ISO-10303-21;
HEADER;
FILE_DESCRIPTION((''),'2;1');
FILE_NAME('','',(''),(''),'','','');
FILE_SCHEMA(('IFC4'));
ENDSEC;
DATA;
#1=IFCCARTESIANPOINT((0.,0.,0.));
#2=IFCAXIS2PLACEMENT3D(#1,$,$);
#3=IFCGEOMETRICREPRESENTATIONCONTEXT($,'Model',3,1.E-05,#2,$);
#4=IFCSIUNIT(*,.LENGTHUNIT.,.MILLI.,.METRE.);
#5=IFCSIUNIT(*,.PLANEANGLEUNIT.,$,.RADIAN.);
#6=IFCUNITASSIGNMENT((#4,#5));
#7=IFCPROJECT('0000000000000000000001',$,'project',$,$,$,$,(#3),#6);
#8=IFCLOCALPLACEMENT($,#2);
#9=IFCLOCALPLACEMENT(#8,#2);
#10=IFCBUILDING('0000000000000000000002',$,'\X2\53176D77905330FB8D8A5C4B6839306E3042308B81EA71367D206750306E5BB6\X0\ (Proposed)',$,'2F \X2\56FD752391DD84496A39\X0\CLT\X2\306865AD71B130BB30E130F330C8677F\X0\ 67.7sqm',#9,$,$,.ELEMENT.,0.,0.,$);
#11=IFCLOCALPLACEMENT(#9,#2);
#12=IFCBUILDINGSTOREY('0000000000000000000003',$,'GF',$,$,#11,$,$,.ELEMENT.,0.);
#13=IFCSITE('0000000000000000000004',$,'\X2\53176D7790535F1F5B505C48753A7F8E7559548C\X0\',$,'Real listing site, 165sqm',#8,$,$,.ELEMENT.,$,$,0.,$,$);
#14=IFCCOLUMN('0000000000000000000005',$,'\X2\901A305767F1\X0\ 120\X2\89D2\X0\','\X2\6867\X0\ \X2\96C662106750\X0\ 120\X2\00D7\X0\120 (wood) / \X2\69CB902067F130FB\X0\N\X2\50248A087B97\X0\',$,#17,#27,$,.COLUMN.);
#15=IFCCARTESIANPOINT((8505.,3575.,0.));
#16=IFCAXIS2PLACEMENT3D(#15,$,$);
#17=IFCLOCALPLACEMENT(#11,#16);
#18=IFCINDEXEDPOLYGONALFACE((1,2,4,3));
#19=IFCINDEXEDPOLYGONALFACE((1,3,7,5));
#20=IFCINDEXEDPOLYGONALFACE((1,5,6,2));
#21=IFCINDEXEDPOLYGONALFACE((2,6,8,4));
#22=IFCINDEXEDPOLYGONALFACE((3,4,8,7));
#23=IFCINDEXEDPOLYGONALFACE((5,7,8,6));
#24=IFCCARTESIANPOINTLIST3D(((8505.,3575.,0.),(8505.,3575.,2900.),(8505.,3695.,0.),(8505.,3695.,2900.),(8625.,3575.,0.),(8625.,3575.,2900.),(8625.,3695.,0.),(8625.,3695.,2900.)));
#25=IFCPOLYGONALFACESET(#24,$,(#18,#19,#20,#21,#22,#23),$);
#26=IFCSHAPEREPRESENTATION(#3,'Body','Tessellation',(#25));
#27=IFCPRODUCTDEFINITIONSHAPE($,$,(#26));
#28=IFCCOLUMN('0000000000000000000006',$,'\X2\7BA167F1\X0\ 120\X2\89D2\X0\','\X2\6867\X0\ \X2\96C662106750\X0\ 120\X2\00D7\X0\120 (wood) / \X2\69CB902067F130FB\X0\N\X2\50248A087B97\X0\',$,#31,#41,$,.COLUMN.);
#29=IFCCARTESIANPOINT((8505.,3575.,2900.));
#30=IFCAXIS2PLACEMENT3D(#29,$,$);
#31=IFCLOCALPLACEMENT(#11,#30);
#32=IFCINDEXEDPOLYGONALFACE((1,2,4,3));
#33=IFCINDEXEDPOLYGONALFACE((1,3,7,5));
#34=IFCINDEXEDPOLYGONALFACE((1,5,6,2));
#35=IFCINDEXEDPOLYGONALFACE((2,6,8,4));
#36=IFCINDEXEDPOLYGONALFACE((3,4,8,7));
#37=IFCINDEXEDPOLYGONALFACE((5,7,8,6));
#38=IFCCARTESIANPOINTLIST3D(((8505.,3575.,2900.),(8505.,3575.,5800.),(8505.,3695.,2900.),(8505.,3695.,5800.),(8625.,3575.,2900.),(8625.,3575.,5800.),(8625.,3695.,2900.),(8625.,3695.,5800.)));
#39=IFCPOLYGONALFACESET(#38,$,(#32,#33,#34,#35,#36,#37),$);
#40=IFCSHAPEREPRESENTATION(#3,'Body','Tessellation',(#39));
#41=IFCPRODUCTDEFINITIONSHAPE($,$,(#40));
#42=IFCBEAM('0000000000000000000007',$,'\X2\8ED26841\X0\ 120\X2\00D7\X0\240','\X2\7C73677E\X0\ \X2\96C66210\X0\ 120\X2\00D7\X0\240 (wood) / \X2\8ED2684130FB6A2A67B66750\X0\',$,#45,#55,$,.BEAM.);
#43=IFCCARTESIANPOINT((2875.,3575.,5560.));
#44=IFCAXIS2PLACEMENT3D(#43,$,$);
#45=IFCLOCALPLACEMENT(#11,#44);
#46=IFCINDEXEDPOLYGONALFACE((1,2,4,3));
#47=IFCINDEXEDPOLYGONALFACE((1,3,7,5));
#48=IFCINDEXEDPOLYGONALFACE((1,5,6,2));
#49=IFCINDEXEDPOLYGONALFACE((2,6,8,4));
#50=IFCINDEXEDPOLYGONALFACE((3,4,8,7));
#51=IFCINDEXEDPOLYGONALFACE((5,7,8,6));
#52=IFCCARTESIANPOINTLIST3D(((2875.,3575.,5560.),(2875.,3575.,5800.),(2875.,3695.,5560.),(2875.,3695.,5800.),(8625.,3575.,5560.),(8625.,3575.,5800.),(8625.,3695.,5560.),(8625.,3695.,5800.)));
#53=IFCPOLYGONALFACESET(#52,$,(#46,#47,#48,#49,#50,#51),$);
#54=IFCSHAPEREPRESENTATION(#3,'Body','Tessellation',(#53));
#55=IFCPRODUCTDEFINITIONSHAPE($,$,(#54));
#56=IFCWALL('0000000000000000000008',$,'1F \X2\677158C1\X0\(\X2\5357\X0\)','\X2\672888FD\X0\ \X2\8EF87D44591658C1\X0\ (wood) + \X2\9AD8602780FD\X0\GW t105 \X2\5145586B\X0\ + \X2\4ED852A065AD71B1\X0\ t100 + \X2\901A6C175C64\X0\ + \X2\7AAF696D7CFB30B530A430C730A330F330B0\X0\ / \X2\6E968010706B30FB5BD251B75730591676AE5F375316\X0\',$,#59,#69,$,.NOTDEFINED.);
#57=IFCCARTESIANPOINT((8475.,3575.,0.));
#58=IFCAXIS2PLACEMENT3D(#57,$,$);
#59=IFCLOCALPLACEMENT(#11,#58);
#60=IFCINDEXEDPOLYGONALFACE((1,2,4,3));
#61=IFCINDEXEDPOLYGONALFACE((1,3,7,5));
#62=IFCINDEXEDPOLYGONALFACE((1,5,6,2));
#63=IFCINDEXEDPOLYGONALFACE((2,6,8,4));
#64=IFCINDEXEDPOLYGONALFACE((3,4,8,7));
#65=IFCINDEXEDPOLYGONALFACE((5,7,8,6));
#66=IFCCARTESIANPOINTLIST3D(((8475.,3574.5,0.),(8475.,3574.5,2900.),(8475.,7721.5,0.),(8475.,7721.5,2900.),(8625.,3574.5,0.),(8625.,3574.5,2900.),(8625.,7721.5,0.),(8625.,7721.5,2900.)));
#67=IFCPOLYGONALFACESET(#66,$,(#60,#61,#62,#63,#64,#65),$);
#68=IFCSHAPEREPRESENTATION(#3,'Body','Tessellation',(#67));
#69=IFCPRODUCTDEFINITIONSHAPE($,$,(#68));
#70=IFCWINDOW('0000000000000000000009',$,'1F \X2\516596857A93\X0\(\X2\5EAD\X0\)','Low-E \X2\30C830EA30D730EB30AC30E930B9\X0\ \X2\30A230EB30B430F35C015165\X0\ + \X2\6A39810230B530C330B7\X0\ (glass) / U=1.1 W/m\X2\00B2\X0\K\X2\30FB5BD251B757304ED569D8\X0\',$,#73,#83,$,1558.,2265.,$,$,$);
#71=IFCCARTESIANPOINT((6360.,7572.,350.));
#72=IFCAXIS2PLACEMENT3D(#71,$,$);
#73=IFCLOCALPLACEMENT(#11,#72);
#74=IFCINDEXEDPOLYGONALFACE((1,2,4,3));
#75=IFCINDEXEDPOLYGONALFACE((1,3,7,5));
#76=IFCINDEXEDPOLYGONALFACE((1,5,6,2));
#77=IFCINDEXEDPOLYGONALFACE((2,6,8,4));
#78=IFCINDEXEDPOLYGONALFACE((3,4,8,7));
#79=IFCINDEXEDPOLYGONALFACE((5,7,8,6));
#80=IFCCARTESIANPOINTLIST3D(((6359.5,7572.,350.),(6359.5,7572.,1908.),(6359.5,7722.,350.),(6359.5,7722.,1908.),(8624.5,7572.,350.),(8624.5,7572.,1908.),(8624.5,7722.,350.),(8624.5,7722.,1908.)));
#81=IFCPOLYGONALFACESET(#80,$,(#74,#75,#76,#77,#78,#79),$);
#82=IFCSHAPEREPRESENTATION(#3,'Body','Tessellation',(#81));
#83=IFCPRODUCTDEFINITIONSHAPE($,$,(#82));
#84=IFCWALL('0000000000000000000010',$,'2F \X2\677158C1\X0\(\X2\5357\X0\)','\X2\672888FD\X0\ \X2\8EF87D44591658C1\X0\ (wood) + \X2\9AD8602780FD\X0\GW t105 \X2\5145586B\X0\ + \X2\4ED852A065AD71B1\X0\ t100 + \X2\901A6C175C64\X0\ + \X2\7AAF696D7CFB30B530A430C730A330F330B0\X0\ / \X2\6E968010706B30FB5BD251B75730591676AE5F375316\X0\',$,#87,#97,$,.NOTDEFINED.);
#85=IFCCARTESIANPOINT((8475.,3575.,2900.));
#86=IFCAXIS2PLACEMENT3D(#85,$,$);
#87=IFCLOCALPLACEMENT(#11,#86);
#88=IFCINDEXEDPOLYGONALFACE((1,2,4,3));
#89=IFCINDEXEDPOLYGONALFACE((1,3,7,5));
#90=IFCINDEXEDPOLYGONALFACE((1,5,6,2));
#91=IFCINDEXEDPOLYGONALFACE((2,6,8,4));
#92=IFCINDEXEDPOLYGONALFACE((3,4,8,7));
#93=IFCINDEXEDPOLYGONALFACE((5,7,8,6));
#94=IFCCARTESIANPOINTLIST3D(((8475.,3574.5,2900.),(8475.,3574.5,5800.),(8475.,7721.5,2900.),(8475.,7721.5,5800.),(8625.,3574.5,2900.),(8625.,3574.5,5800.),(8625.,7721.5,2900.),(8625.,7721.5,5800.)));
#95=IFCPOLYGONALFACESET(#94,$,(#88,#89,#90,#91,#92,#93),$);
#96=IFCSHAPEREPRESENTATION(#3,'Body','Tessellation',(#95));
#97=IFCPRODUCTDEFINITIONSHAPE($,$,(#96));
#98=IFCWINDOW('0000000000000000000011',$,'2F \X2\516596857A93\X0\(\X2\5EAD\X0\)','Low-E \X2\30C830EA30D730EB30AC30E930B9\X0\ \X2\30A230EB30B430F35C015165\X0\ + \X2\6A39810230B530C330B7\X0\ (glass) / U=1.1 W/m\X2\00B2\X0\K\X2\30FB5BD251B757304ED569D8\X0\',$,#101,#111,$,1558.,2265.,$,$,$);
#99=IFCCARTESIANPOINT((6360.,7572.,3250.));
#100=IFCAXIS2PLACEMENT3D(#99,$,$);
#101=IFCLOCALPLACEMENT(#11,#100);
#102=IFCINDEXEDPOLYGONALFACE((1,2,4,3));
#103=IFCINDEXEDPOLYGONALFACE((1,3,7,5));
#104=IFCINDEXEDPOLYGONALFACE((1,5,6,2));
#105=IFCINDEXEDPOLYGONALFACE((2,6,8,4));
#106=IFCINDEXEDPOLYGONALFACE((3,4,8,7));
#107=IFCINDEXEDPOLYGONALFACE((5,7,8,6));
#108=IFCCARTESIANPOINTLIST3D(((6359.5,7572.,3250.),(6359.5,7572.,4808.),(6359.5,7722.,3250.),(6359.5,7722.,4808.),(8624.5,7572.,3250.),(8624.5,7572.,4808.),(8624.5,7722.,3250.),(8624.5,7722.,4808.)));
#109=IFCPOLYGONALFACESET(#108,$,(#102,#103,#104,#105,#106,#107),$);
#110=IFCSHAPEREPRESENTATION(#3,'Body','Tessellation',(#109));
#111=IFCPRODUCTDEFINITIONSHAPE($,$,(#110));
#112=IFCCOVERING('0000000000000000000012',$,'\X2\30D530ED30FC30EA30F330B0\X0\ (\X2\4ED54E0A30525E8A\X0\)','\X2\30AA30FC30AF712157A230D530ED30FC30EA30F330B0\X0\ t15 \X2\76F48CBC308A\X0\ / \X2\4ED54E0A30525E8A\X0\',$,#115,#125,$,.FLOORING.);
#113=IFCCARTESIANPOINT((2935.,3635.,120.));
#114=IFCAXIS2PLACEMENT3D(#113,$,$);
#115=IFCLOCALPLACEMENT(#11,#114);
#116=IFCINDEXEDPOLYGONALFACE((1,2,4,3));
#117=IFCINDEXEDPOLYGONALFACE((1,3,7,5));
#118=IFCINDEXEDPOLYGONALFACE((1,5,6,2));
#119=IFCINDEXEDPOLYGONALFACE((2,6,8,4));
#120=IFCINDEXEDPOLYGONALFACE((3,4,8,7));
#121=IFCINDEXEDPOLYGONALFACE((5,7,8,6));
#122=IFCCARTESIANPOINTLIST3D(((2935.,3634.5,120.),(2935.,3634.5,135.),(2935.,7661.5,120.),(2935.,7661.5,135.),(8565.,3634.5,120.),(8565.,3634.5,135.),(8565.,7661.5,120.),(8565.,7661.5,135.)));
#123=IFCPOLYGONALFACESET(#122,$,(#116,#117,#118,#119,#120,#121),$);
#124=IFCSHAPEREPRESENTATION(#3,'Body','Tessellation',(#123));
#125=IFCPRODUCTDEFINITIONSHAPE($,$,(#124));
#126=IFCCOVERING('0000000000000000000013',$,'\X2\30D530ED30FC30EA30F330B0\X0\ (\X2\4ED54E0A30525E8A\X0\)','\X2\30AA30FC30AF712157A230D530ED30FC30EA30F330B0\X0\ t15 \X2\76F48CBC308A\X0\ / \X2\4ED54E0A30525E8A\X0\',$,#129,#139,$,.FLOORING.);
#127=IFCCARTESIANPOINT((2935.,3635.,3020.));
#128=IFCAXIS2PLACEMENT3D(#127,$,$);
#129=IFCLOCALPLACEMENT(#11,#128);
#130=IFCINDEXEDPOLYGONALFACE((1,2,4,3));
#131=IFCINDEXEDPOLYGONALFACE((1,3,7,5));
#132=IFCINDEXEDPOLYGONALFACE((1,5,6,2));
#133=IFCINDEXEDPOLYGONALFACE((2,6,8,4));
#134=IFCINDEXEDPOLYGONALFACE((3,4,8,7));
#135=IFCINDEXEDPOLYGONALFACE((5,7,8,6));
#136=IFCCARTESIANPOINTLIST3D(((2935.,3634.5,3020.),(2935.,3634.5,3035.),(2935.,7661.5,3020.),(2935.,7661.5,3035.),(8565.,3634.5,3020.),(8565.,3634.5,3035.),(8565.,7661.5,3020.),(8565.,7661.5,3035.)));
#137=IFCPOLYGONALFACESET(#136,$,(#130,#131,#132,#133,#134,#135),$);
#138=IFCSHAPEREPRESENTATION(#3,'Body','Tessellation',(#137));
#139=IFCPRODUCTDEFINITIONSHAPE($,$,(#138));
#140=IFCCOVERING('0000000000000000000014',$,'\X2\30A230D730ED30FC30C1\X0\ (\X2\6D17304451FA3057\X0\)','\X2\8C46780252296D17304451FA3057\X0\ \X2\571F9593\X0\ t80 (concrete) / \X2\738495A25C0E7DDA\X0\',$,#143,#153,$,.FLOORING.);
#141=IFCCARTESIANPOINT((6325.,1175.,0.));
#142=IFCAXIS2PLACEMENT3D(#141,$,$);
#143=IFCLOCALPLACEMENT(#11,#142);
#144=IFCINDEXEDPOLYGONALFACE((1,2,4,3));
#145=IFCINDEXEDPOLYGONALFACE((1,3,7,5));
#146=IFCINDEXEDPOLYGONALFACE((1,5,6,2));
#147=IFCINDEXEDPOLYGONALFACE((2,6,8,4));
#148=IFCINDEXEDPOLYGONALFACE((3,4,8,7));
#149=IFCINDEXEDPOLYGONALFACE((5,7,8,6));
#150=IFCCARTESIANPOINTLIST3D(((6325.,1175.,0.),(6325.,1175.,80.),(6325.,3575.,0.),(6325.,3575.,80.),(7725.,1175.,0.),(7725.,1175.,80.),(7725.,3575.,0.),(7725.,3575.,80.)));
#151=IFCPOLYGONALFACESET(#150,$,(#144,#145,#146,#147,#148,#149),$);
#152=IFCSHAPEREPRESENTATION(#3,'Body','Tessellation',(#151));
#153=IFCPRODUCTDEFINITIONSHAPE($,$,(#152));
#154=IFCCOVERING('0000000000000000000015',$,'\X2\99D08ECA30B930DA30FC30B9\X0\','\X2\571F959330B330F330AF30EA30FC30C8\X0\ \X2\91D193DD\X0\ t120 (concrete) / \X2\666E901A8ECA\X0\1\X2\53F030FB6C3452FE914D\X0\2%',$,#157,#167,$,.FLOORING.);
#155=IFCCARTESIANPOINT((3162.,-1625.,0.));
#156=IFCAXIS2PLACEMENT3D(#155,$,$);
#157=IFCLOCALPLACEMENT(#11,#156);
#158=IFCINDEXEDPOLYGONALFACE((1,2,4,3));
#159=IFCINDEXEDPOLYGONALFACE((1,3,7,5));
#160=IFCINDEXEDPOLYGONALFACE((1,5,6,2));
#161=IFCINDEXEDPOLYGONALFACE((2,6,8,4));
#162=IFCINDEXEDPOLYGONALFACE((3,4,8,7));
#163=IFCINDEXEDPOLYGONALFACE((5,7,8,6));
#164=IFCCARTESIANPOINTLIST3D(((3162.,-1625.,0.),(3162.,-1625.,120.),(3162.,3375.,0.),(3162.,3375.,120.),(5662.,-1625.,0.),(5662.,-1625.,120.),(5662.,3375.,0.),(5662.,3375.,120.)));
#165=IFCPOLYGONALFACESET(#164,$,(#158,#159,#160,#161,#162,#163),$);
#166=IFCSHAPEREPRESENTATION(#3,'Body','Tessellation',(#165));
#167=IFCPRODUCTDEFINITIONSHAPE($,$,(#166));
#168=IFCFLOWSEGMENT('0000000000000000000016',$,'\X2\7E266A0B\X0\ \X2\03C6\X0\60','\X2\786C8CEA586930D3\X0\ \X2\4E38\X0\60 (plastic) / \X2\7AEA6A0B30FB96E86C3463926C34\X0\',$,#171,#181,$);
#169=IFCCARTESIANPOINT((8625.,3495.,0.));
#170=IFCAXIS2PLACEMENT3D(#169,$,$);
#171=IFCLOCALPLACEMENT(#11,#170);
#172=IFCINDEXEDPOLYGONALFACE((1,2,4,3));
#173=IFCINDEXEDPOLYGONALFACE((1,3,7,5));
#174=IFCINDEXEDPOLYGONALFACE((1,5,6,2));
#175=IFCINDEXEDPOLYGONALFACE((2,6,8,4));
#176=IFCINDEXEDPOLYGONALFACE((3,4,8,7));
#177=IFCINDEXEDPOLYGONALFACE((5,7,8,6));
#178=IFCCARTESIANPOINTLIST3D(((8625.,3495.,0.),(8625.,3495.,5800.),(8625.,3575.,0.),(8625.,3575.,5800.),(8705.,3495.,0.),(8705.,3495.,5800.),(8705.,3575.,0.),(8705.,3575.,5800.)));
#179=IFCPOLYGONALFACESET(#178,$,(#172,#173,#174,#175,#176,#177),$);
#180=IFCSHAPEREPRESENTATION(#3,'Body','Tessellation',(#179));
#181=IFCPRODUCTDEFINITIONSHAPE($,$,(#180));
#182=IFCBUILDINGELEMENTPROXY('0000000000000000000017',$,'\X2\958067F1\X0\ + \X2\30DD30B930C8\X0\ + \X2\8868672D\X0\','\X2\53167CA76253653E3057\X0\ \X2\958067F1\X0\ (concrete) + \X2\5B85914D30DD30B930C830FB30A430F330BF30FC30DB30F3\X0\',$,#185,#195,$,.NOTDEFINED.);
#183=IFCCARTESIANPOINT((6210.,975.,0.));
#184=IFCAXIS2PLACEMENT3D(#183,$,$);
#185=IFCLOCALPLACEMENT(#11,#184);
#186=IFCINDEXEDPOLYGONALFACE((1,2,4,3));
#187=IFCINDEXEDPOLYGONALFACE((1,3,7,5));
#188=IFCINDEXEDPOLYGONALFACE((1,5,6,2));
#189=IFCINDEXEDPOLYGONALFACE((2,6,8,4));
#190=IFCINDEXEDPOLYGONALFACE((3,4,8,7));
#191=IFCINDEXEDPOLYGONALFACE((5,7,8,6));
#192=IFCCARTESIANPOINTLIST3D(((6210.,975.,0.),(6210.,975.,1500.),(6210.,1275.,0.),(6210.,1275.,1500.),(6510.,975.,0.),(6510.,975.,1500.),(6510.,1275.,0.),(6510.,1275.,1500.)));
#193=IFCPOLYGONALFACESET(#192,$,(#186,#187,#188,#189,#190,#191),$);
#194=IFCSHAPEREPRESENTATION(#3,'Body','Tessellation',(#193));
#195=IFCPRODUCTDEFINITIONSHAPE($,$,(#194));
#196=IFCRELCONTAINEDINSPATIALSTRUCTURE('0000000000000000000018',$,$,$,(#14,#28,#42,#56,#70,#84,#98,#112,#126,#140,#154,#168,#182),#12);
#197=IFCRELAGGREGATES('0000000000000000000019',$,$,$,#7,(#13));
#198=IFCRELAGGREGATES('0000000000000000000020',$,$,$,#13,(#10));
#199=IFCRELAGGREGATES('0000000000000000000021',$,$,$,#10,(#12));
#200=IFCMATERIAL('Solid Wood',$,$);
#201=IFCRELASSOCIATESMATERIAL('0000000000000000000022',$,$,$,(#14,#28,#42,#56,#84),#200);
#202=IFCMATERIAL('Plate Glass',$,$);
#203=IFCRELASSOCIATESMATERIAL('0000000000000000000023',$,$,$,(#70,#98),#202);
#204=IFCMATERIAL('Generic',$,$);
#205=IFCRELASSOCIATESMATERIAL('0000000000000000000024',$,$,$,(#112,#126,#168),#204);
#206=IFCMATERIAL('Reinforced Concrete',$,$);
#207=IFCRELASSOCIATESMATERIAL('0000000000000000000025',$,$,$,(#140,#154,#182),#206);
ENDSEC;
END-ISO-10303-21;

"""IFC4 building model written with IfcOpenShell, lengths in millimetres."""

from ifc_helpers import new_model, si_unit, frame, frame_2d, origin, place, context, project, spatial, rectangle, extrude, material, element, fill, save


model = new_model("IFC4")

# Units and contexts
model_context = context("Model", 3, precision=1e-05, world=origin())
ifc_project = project(units=[si_unit("LENGTHUNIT", "METRE", prefix="MILLI"), si_unit("PLANEANGLEUNIT", "RADIAN")], contexts=[model_context])

# Site, building, storey
site_placement = place(None, origin())
site = spatial("IfcSite", under=ifc_project, at=site_placement, Name="北海道弟子屈町美留和", ObjectType="Real listing site, 165sqm", CompositionType="ELEMENT", RefElevation=0.0)
building_placement = place(site_placement, origin())
building = spatial("IfcBuilding", under=site, at=building_placement, Name="北海道・越屋根のある自然素材の家 (Proposed)", ObjectType="2F 国産針葉樹CLTと断熱セメント板 67.7sqm", CompositionType="ELEMENT", ElevationOfRefHeight=0.0, ElevationOfTerrain=0.0)
storey_placement = place(building_placement, origin())
storey = spatial("IfcBuildingStorey", under=building, at=storey_placement, Name="GF", CompositionType="ELEMENT", Elevation=0.0)

# Columns
ifc_material_1 = material(Name="Solid Wood")
column_1_placement = place(storey_placement, frame((8505.0, 3575.0, 0.0)))
element("IfcColumn", 1, at=column_1_placement, inside=storey, material=ifc_material_1, Name="通し柱 120角", Description="桧 集成材 120×120 (wood) / 構造柱・N値計算", PredefinedType="COLUMN", context=model_context, shape_type="SweptSolid", body=[
    extrude(rectangle(XDim=120.0, YDim=120.0, at=frame_2d((60.0, 60.0))), frame((8505.0, 3575.0, 0.0)), (0.0, 0.0, 1.0), 2900.0),
])
column_2_placement = place(storey_placement, frame((8505.0, 3575.0, 2900.0)))
element("IfcColumn", 2, at=column_2_placement, inside=storey, material=ifc_material_1, Name="管柱 120角", Description="桧 集成材 120×120 (wood) / 構造柱・N値計算", PredefinedType="COLUMN", context=model_context, shape_type="SweptSolid", body=[
    extrude(rectangle(XDim=120.0, YDim=120.0, at=frame_2d((60.0, 60.0))), frame((8505.0, 3575.0, 2900.0)), (0.0, 0.0, 1.0), 2900.0),
])

# Beam
beam_1_placement = place(storey_placement, frame((2875.0, 3575.0, 5560.0)))
element("IfcBeam", 3, at=beam_1_placement, inside=storey, material=ifc_material_1, Name="軒桁 120×240", Description="米松 集成 120×240 (wood) / 軒桁・横架材", PredefinedType="BEAM", context=model_context, shape_type="SweptSolid", body=[
    extrude(rectangle(XDim=5750.0, YDim=120.0, at=frame_2d((2875.0, 60.0))), frame((2875.0, 3575.0, 5560.0)), (0.0, 0.0, 1.0), 240.0),
])

# Wall, opening, window
wall_1_placement = place(storey_placement, frame((8475.0, 3575.0, 0.0)))
wall_1 = element("IfcWall", 4, at=wall_1_placement, inside=storey, material=ifc_material_1, Name="1F 東壁(南)", Description="木製 軸組外壁 (wood) + 高性能GW t105 充填 + 付加断熱 t100 + 通気層 + 窯業系サイディング / 準耐火・寒冷地外皮強化", PredefinedType="NOTDEFINED", context=model_context, shape_type="SweptSolid", body=[
    extrude(rectangle(XDim=150.0, YDim=4147.0, at=frame_2d((75.0, 2073.0))), frame((8475.0, 3575.0, 0.0)), (0.0, 0.0, 1.0), 2900.0),
])
opening_1_placement = place(storey_placement, frame((6360.0, 7572.0, 350.0)))
opening_1 = element("IfcOpeningElement", 5, at=opening_1_placement, cuts=wall_1, PredefinedType="NOTDEFINED", context=model_context, shape_type="SweptSolid", body=[
    extrude(rectangle(XDim=2265.0, YDim=150.0, at=frame_2d((1132.0, 75.0))), frame((6360.0, 7572.0, 350.0)), (0.0, 0.0, 1.0), 1558.0),
])
ifc_material_2 = material(Name="Plate Glass")
window_1_placement = place(storey_placement, frame((6360.0, 7572.0, 350.0)))
window_1 = element("IfcWindow", 6, at=window_1_placement, inside=storey, material=ifc_material_2, Name="1F 入隅窓(庭)", Description="Low-E トリプルガラス アルゴン封入 + 樹脂サッシ (glass) / U=1.1 W/m²K・寒冷地仕様", OverallHeight=1558.0, OverallWidth=2265.0, context=model_context, shape_type="SweptSolid", body=[
    extrude(rectangle(XDim=2265.0, YDim=150.0, at=frame_2d((1132.0, 75.0))), frame((6360.0, 7572.0, 350.0)), (0.0, 0.0, 1.0), 1558.0),
])
fill(opening_1, window_1)

# Wall, opening, window
wall_2_placement = place(storey_placement, frame((8475.0, 3575.0, 2900.0)))
wall_2 = element("IfcWall", 7, at=wall_2_placement, inside=storey, material=ifc_material_1, Name="2F 東壁(南)", Description="木製 軸組外壁 (wood) + 高性能GW t105 充填 + 付加断熱 t100 + 通気層 + 窯業系サイディング / 準耐火・寒冷地外皮強化", PredefinedType="NOTDEFINED", context=model_context, shape_type="SweptSolid", body=[
    extrude(rectangle(XDim=150.0, YDim=4147.0, at=frame_2d((75.0, 2073.0))), frame((8475.0, 3575.0, 2900.0)), (0.0, 0.0, 1.0), 2900.0),
])
opening_2_placement = place(storey_placement, frame((6360.0, 7572.0, 3250.0)))
opening_2 = element("IfcOpeningElement", 8, at=opening_2_placement, cuts=wall_2, PredefinedType="NOTDEFINED", context=model_context, shape_type="SweptSolid", body=[
    extrude(rectangle(XDim=2265.0, YDim=150.0, at=frame_2d((1132.0, 75.0))), frame((6360.0, 7572.0, 3250.0)), (0.0, 0.0, 1.0), 1558.0),
])
window_2_placement = place(storey_placement, frame((6360.0, 7572.0, 3250.0)))
window_2 = element("IfcWindow", 9, at=window_2_placement, inside=storey, material=ifc_material_2, Name="2F 入隅窓(庭)", Description="Low-E トリプルガラス アルゴン封入 + 樹脂サッシ (glass) / U=1.1 W/m²K・寒冷地仕様", OverallHeight=1558.0, OverallWidth=2265.0, context=model_context, shape_type="SweptSolid", body=[
    extrude(rectangle(XDim=2265.0, YDim=150.0, at=frame_2d((1132.0, 75.0))), frame((6360.0, 7572.0, 3250.0)), (0.0, 0.0, 1.0), 1558.0),
])
fill(opening_2, window_2)

# Coverings
ifc_material_3 = material(Name="Generic")
covering_1_placement = place(storey_placement, frame((2935.0, 3635.0, 120.0)))
element("IfcCovering", 10, at=covering_1_placement, inside=storey, material=ifc_material_3, Name="フローリング (仕上げ床)", Description="オーク無垢フローリング t15 直貼り / 仕上げ床", PredefinedType="FLOORING", context=model_context, shape_type="SweptSolid", body=[
    extrude(rectangle(XDim=5630.0, YDim=4027.0, at=frame_2d((2815.0, 2013.0))), frame((2935.0, 3635.0, 120.0)), (0.0, 0.0, 1.0), 15.0),
])
covering_2_placement = place(storey_placement, frame((2935.0, 3635.0, 3020.0)))
element("IfcCovering", 11, at=covering_2_placement, inside=storey, material=ifc_material_3, Name="フローリング (仕上げ床)", Description="オーク無垢フローリング t15 直貼り / 仕上げ床", PredefinedType="FLOORING", context=model_context, shape_type="SweptSolid", body=[
    extrude(rectangle(XDim=5630.0, YDim=4027.0, at=frame_2d((2815.0, 2013.0))), frame((2935.0, 3635.0, 3020.0)), (0.0, 0.0, 1.0), 15.0),
])
ifc_material_4 = material(Name="Reinforced Concrete")
covering_3_placement = place(storey_placement, frame((6325.0, 1175.0, 0.0)))
element("IfcCovering", 12, at=covering_3_placement, inside=storey, material=ifc_material_4, Name="アプローチ (洗い出し)", Description="豆砂利洗い出し 土間 t80 (concrete) / 玄関導線", PredefinedType="FLOORING", context=model_context, shape_type="SweptSolid", body=[
    extrude(rectangle(XDim=1400.0, YDim=2400.0, at=frame_2d((700.0, 1200.0))), frame((6325.0, 1175.0, 0.0)), (0.0, 0.0, 1.0), 80.0),
])
covering_4_placement = place(storey_placement, frame((3162.0, -1625.0, 0.0)))
element("IfcCovering", 13, at=covering_4_placement, inside=storey, material=ifc_material_4, Name="駐車スペース", Description="土間コンクリート 金鏝 t120 (concrete) / 普通車1台・水勾配2%", PredefinedType="FLOORING", context=model_context, shape_type="SweptSolid", body=[
    extrude(rectangle(XDim=2500.0, YDim=5000.0, at=frame_2d((1250.0, 2500.0))), frame((3162.0, -1625.0, 0.0)), (0.0, 0.0, 1.0), 120.0),
])

# Flow segment
flow_segment_placement = place(storey_placement, frame((8625.0, 3495.0, 0.0)))
element("IfcFlowSegment", 14, at=flow_segment_placement, inside=storey, material=ifc_material_3, Name="縦樋 φ60", Description="硬質塩ビ 丸60 (plastic) / 竪樋・雨水排水", context=model_context, shape_type="SweptSolid", body=[
    extrude(rectangle(XDim=80.0, YDim=80.0, at=frame_2d((40.0, 40.0))), frame((8625.0, 3495.0, 0.0)), (0.0, 0.0, 1.0), 5800.0),
])

# Building element proxy
proxy_placement = place(storey_placement, frame((6210.0, 975.0, 0.0)))
element("IfcBuildingElementProxy", 15, at=proxy_placement, inside=storey, material=ifc_material_4, Name="門柱 + ポスト + 表札", Description="化粧打放し 門柱 (concrete) + 宅配ポスト・インターホン", PredefinedType="NOTDEFINED", context=model_context, shape_type="SweptSolid", body=[
    extrude(rectangle(XDim=300.0, YDim=300.0, at=frame_2d((150.0, 150.0))), frame((6210.0, 975.0, 0.0)), (0.0, 0.0, 1.0), 1500.0),
])

save(model, "model.ifc")
